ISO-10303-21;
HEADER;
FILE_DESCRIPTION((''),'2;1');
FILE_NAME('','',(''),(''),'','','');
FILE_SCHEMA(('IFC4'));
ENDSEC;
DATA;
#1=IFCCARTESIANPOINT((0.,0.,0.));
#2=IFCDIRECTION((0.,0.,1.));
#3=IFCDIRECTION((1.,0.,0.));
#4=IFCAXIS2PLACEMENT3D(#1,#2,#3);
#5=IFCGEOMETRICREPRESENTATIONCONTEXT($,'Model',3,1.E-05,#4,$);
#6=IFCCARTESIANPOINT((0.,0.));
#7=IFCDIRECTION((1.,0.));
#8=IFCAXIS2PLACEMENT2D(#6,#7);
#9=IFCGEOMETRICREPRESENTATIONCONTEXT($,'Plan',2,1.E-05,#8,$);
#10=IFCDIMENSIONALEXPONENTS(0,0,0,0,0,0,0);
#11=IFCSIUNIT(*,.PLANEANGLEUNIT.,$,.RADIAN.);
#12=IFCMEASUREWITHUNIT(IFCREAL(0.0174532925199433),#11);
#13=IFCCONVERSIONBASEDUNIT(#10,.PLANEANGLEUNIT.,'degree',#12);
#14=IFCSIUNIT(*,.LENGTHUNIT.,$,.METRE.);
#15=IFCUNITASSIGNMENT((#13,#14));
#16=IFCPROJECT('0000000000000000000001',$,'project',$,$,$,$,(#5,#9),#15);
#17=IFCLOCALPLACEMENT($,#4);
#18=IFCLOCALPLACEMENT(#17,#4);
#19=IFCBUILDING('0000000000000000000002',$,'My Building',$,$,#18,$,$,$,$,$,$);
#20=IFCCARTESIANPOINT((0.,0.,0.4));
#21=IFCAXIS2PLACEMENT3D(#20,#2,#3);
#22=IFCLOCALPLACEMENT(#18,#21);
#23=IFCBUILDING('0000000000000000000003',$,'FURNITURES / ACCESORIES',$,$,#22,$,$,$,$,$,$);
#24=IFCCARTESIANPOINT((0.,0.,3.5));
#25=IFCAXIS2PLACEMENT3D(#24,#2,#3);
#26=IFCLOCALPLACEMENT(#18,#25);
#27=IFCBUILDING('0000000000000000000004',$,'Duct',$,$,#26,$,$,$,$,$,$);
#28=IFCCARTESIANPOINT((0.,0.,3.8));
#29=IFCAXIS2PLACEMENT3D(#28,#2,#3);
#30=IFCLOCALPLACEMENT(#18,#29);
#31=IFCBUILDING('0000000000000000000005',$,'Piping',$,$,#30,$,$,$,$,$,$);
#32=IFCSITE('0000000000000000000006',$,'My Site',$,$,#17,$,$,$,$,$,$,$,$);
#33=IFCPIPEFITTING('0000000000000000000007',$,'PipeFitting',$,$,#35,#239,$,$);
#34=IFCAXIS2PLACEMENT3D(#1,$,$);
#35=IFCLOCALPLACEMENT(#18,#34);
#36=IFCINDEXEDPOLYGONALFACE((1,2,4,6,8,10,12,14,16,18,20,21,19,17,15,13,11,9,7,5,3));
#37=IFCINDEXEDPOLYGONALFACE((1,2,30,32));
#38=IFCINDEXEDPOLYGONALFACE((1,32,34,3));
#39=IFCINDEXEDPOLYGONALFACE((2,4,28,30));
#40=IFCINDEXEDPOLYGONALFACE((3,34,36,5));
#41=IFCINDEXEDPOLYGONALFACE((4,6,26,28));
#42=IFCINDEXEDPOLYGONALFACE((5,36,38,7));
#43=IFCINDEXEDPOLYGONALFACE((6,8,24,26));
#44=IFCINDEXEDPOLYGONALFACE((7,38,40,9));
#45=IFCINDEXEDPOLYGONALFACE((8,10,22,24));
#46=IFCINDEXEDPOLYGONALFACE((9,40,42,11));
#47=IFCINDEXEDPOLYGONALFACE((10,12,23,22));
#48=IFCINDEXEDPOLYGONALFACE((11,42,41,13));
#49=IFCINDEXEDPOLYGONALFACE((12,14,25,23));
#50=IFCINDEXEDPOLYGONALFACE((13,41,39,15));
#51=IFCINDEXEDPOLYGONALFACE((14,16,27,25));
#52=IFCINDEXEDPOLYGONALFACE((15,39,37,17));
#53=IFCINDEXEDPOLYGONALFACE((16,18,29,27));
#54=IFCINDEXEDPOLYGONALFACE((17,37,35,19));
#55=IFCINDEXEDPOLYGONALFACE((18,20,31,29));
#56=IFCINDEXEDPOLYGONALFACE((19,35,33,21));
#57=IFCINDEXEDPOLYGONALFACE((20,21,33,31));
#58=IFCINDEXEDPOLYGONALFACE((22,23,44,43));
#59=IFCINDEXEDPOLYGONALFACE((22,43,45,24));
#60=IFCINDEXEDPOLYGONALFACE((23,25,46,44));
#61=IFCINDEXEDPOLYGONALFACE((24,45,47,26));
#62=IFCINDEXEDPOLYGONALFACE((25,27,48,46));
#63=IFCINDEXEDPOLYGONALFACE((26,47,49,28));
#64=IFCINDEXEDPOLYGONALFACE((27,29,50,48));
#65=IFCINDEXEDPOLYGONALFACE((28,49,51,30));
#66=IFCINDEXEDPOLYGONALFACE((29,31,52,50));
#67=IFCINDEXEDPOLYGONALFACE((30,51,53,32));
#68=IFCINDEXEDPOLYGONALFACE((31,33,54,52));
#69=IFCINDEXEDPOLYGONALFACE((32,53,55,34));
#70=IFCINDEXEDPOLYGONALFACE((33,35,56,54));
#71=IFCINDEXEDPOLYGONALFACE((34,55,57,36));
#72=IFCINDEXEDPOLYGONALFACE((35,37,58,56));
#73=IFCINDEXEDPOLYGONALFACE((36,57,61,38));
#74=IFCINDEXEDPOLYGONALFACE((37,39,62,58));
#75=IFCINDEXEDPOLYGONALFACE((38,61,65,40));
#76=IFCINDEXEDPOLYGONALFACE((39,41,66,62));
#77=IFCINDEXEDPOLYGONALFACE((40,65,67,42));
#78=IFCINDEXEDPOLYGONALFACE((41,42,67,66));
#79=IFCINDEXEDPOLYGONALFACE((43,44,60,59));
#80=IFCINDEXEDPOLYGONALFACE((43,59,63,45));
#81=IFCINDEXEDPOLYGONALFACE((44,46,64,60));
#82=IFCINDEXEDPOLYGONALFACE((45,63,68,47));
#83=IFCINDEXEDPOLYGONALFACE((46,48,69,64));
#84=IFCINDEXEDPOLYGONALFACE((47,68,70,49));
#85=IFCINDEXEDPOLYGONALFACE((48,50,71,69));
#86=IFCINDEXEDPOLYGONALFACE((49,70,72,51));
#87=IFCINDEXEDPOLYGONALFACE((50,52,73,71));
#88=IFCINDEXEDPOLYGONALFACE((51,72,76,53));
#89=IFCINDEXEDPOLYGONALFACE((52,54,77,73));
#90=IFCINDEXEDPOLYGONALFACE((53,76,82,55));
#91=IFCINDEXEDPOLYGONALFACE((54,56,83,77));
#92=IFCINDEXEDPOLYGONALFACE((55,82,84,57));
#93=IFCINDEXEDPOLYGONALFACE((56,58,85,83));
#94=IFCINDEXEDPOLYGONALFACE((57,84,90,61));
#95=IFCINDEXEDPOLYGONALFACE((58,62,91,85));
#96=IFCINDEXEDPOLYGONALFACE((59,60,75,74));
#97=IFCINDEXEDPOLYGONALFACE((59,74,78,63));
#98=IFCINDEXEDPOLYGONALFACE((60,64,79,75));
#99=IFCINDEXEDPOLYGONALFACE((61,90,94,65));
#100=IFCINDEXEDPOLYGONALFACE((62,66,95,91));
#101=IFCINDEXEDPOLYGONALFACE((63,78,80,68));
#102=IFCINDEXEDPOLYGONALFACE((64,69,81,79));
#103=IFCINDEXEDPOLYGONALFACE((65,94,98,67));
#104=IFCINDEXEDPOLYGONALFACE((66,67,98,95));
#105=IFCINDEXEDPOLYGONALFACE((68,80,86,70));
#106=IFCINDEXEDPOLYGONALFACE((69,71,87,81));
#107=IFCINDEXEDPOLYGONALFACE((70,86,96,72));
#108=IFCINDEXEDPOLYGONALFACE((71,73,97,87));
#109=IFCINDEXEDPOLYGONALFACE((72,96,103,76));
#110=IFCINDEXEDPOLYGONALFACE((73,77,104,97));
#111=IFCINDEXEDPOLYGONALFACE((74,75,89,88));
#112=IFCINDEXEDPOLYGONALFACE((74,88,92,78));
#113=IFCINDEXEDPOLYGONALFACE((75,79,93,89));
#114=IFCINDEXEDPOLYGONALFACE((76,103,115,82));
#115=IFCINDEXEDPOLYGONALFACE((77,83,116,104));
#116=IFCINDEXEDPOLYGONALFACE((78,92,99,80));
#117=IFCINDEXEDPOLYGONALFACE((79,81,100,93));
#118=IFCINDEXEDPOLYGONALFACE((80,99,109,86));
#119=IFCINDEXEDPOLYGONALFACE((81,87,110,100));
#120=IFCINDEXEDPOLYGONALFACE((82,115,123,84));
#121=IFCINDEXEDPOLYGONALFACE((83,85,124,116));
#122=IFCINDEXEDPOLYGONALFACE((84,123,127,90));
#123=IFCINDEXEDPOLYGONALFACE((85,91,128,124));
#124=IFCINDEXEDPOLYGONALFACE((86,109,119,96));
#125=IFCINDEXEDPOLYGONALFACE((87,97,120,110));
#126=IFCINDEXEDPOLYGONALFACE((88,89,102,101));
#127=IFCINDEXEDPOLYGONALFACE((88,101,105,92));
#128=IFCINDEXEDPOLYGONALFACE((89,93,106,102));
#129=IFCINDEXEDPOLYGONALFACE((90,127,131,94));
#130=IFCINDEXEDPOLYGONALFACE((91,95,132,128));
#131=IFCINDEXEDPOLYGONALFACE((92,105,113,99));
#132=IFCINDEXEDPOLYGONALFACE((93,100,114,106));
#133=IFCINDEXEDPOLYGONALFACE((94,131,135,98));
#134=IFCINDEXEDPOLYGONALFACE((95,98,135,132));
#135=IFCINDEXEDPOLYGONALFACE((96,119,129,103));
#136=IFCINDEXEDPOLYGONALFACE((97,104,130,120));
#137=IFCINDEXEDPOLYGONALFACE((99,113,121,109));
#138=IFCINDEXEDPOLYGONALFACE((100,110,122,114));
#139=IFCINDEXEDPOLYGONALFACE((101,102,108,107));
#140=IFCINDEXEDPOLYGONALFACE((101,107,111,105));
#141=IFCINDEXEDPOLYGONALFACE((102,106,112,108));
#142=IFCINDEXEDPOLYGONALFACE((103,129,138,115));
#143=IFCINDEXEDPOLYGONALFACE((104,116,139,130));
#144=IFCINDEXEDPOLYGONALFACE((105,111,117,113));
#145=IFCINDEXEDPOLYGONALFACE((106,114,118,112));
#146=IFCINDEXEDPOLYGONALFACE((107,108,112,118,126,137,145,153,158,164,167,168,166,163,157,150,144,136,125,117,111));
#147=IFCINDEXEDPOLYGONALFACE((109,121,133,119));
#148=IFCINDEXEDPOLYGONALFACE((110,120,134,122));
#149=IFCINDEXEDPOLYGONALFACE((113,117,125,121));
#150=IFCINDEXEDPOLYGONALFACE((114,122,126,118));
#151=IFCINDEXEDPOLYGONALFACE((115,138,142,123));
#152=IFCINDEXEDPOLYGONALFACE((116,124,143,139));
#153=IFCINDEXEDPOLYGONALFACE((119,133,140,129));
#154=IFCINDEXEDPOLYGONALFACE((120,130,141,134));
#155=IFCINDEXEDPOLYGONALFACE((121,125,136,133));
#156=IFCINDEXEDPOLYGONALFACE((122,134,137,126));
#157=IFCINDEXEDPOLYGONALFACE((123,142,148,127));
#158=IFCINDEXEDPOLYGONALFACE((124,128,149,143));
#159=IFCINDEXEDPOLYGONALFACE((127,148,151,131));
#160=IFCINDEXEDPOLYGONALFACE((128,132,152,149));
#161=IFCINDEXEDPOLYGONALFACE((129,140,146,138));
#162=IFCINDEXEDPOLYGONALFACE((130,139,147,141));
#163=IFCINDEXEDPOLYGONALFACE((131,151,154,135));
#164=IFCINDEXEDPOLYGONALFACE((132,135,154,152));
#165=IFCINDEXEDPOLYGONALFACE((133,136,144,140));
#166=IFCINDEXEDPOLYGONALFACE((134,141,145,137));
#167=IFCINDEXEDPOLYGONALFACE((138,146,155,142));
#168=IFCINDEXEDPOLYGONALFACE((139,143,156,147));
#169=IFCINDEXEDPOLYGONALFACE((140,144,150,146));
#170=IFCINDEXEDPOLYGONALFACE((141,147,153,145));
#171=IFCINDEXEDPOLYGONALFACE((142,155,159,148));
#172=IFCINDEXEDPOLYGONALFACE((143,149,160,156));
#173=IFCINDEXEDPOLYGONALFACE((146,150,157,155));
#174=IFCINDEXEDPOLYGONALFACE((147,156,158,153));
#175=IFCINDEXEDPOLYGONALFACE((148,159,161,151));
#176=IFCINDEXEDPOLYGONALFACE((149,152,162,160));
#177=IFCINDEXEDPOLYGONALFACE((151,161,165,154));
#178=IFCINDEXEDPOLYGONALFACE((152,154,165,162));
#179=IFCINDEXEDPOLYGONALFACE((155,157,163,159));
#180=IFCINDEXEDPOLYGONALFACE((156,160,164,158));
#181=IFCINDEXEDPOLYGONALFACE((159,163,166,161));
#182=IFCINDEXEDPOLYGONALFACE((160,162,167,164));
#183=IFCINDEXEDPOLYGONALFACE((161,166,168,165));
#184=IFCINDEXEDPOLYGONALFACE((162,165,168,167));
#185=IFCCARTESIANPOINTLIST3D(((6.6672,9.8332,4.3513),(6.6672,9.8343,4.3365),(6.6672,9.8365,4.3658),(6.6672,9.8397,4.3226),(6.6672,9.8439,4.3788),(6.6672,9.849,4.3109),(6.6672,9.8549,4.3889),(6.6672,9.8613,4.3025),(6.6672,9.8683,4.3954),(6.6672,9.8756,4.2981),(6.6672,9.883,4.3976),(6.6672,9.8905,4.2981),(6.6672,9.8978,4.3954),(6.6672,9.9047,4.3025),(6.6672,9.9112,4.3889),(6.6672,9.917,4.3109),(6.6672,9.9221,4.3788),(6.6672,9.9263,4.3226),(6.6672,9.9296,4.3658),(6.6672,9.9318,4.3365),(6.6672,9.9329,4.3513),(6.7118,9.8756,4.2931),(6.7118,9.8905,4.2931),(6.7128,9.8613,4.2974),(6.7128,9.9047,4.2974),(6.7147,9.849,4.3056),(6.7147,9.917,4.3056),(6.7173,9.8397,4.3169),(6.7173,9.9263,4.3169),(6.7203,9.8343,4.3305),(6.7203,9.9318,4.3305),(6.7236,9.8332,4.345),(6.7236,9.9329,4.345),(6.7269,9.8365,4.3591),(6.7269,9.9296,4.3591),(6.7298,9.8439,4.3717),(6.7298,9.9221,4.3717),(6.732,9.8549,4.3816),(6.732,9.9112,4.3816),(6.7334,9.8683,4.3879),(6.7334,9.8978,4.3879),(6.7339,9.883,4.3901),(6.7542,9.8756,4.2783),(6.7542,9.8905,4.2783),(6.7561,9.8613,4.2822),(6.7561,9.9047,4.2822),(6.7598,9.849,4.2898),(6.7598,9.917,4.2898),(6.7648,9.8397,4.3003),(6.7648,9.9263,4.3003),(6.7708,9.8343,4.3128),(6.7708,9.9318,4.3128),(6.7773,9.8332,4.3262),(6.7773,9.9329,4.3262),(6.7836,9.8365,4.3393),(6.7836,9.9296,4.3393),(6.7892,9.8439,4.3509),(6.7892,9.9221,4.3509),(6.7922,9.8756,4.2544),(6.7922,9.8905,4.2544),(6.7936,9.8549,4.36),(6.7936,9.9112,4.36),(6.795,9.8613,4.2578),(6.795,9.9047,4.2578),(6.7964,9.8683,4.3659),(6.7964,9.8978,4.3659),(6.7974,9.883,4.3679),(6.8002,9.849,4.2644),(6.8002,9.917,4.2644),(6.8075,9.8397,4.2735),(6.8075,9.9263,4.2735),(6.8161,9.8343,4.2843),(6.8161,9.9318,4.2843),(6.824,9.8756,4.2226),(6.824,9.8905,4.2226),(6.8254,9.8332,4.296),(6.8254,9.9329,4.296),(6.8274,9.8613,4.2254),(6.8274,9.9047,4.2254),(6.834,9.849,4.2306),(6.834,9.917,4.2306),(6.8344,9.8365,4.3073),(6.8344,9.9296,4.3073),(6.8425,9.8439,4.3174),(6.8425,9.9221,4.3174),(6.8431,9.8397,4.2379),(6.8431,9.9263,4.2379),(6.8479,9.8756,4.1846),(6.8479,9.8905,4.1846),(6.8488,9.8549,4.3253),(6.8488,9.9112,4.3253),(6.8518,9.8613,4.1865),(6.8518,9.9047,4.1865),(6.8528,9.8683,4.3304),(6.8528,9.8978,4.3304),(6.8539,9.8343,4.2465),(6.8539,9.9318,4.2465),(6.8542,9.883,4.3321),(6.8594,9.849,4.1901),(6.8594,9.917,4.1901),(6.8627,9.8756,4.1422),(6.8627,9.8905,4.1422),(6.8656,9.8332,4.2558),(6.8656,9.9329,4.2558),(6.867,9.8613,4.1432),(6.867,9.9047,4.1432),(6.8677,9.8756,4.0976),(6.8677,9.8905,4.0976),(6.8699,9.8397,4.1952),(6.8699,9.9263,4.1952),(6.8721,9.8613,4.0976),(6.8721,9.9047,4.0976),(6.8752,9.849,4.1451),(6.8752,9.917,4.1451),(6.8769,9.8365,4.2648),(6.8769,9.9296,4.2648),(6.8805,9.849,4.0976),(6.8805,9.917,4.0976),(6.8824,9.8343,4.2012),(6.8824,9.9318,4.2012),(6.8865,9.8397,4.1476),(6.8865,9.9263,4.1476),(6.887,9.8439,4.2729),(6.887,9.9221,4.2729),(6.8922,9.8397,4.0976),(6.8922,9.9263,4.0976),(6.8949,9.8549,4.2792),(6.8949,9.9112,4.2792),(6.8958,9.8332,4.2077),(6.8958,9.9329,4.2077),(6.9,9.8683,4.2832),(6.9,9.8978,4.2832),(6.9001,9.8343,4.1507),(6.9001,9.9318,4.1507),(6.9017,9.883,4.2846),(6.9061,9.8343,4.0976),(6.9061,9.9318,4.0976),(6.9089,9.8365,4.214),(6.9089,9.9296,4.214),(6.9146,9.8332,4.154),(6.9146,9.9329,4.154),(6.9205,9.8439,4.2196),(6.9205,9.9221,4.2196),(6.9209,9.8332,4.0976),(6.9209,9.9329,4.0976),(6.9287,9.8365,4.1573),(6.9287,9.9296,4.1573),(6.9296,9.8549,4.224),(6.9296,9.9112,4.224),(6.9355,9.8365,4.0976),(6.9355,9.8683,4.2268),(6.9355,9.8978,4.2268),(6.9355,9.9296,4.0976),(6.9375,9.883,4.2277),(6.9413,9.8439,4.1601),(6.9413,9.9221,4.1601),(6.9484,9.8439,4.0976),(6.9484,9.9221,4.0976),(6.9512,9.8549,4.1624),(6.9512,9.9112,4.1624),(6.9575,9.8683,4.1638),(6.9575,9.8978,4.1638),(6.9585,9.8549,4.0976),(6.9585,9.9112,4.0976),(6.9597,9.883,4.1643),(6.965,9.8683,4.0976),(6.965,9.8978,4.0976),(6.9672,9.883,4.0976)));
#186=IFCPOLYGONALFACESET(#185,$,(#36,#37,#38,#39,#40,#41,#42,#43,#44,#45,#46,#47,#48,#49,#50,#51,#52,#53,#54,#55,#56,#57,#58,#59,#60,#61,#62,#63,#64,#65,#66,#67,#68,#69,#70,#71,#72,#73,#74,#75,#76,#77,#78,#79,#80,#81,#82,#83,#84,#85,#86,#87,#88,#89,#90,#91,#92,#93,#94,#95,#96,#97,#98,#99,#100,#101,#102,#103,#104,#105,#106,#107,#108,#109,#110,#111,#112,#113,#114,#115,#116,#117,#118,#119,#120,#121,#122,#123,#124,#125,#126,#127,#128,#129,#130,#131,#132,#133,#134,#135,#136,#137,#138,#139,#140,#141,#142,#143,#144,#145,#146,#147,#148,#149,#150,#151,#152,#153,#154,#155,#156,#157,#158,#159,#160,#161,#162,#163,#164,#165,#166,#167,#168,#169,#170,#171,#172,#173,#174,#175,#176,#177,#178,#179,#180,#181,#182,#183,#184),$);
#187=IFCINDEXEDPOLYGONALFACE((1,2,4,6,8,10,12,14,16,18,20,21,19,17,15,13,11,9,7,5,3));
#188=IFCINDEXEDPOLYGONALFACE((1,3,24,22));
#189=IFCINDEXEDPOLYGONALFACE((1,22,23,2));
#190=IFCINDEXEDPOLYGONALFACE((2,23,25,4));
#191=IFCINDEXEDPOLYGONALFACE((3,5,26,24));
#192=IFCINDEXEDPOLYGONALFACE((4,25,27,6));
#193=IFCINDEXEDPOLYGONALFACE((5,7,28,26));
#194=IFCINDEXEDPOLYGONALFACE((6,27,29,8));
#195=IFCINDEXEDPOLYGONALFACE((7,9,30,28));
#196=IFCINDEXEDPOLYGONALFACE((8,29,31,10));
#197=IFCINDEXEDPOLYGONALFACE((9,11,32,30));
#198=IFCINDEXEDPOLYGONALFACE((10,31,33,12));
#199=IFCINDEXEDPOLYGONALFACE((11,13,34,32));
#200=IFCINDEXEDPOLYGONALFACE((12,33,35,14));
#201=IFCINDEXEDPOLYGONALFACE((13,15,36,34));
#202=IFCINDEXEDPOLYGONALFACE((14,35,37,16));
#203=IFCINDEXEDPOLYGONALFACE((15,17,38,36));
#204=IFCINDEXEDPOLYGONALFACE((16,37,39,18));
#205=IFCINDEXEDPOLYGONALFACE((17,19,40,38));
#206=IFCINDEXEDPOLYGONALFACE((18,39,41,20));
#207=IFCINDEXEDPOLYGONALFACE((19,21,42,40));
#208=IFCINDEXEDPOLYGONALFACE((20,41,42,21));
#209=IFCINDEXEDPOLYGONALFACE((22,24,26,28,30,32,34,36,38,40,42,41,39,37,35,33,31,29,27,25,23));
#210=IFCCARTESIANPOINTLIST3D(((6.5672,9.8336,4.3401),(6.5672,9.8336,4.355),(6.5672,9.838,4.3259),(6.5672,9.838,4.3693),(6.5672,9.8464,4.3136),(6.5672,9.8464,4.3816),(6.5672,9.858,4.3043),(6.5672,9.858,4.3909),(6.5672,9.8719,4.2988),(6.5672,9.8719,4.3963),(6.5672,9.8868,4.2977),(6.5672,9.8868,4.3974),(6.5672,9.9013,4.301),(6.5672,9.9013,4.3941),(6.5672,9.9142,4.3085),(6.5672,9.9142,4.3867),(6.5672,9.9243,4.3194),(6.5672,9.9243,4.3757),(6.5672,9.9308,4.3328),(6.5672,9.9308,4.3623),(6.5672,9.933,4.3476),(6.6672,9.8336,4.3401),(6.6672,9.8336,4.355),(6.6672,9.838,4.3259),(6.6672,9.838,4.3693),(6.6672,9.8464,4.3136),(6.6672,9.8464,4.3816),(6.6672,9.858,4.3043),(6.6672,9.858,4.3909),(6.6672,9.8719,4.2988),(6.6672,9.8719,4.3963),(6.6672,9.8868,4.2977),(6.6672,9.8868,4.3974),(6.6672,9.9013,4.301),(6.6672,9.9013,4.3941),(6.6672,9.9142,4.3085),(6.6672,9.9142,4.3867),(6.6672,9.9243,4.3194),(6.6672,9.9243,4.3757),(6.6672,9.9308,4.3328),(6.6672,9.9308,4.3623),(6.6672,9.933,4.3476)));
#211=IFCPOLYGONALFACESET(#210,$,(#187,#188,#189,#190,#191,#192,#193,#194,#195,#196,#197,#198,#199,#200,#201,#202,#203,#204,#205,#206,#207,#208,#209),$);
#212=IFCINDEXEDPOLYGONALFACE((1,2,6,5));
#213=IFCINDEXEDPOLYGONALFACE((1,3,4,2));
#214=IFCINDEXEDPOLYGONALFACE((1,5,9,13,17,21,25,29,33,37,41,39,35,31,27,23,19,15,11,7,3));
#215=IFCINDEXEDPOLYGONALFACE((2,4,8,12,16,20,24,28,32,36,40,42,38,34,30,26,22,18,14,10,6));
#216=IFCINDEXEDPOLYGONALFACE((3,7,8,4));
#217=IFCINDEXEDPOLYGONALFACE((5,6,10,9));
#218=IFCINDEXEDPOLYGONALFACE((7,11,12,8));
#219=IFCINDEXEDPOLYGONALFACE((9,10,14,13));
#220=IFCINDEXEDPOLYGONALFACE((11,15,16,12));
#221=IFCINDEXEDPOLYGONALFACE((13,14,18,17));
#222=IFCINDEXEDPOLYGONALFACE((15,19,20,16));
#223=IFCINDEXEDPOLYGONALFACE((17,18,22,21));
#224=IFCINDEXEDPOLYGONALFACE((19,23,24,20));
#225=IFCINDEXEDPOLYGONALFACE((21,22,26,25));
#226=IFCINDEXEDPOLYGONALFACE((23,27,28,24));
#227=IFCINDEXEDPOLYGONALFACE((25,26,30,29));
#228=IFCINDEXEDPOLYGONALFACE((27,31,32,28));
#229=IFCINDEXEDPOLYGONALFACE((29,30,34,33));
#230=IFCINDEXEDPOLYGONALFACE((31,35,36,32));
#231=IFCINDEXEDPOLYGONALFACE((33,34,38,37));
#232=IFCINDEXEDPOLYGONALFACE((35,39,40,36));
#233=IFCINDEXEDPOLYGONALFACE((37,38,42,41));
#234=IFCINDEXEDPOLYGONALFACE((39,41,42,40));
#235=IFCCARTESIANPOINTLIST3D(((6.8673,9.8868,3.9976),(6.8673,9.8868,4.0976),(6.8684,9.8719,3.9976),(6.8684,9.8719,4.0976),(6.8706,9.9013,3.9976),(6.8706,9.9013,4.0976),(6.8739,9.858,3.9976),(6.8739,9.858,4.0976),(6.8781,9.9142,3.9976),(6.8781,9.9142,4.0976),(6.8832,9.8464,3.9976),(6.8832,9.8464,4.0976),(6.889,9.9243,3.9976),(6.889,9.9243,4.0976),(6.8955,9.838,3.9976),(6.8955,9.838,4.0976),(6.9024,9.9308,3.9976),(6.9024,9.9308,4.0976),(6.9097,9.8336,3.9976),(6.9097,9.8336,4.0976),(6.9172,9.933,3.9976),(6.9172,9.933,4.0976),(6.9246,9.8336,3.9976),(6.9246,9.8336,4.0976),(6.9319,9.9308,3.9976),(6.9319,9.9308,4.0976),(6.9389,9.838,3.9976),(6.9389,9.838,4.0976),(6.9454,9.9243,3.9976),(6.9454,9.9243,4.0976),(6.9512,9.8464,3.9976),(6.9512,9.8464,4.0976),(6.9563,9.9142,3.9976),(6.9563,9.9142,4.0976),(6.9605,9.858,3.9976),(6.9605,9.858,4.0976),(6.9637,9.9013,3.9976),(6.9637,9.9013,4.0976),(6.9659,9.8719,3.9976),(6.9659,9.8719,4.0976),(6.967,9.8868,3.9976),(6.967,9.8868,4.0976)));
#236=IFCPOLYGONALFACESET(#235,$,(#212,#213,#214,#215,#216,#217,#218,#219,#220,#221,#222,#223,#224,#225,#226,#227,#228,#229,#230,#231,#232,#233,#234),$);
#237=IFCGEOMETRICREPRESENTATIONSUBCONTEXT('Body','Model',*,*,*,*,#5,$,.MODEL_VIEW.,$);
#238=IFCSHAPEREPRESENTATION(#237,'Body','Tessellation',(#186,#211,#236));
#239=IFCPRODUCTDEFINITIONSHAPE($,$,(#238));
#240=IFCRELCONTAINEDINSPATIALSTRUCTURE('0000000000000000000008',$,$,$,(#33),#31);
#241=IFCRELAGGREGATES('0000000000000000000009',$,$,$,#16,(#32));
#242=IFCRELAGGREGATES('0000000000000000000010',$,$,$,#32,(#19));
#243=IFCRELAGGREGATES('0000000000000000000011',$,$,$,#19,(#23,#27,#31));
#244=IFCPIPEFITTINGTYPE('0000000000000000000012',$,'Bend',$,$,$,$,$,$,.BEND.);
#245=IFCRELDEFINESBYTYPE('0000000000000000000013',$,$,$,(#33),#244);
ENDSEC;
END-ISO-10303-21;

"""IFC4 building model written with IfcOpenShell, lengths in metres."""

from ifc_helpers import new_model, entity, si_unit, converted_unit, frame, origin_with_axes, origin_2d_with_axis, place, context, subcontext, project, spatial, circle, extrude, source, transform, mapped, type_object, type_shapes, element, save


model = new_model("IFC4")

# Units and contexts
model_context = context("Model", 3, precision=1e-05, world=origin_with_axes())
plan_context = context("Plan", 2, precision=1e-05, world=origin_2d_with_axis())
body_context_1 = subcontext(model_context, "Body", "Model", "MODEL_VIEW")
ifc_project = project(units=[converted_unit("PLANEANGLEUNIT", "degree", entity("IfcReal", 0.0174532925199433), si_unit("PLANEANGLEUNIT", "RADIAN"), dimensions=[0, 0, 0, 0, 0, 0, 0]), si_unit("LENGTHUNIT", "METRE")], contexts=[model_context, plan_context])

# Site, building
site_placement = place(None, origin_with_axes())
site = spatial("IfcSite", under=ifc_project, at=site_placement, Name="My Site")
building_1_placement = place(site_placement, origin_with_axes())
building_1 = spatial("IfcBuilding", under=site, at=building_1_placement, Name="My Building")

# Shared definitions
building_2_placement = place(building_1_placement, frame((0.0, 0.0, 0.4), z_axis=(0.0, 0.0, 1.0), x_axis=(1.0, 0.0, 0.0)))
building_2 = spatial("IfcBuilding", under=building_1, at=building_2_placement, Name="FURNITURES / ACCESORIES")

# Shared definitions
building_3_placement = place(building_1_placement, frame((0.0, 0.0, 3.5), z_axis=(0.0, 0.0, 1.0), x_axis=(1.0, 0.0, 0.0)))
building_3 = spatial("IfcBuilding", under=building_1, at=building_3_placement, Name="Duct")

# Shared definitions
building_4_placement = place(building_1_placement, frame((0.0, 0.0, 3.8), z_axis=(0.0, 0.0, 1.0), x_axis=(1.0, 0.0, 0.0)))
building_4 = spatial("IfcBuilding", under=building_1, at=building_4_placement, Name="Piping")

# Pipe fitting
pipe_fitting_type = type_object("IfcPipeFittingType", Name="Bend", PredefinedType="BEND")
shared_shape_1 = source(origin_with_axes(), body_context_1, "Body", "SolidModel", [
    entity("IfcSweptDiskSolid", entity("IfcIndexedPolyCurve", entity("IfcCartesianPointList3D", [[0.0, 0.0, 0.1], [0.0, -0.0732, 0.2768], [0.0, -0.25, 0.35]]), [entity("IfcArcIndex", [1, 2, 3])]), 0.05),
    extrude(circle(Radius=0.05), origin_with_axes(), (0.0, 0.0, 1.0), 0.1),
    extrude(circle(Radius=0.05), frame((0.0, -0.25, 0.35), z_axis=(0.0, -1.0, -0.000001), x_axis=(1.0, 0.0, 0.0)), (0.0, 0.0, 1.0), 0.1),
])
type_shapes(pipe_fitting_type, [shared_shape_1])
for number, where, z_axis, x_axis, name in (
    (1, (6.5672, 9.883, 0.5476), (1.0, -0.000001, 0.000001), (0.000001, 1.0, 0.0), "PipeFitting"),
):
    element("IfcPipeFitting", number, at=place(building_4_placement, frame(where, z_axis=z_axis, x_axis=x_axis)), inside=building_4, type_object=pipe_fitting_type, Name=name, context=body_context_1, shape_type="MappedRepresentation", body=[
        mapped(shared_shape_1, transform((0.0, 0.0, 0.0), x_axis=(1.0, 0.0, 0.0), y_axis=(0.0, 1.0, 0.0), z_axis=(0.0, 0.0, 1.0), scale=1.0)),
    ])

save(model, "model.ifc")
